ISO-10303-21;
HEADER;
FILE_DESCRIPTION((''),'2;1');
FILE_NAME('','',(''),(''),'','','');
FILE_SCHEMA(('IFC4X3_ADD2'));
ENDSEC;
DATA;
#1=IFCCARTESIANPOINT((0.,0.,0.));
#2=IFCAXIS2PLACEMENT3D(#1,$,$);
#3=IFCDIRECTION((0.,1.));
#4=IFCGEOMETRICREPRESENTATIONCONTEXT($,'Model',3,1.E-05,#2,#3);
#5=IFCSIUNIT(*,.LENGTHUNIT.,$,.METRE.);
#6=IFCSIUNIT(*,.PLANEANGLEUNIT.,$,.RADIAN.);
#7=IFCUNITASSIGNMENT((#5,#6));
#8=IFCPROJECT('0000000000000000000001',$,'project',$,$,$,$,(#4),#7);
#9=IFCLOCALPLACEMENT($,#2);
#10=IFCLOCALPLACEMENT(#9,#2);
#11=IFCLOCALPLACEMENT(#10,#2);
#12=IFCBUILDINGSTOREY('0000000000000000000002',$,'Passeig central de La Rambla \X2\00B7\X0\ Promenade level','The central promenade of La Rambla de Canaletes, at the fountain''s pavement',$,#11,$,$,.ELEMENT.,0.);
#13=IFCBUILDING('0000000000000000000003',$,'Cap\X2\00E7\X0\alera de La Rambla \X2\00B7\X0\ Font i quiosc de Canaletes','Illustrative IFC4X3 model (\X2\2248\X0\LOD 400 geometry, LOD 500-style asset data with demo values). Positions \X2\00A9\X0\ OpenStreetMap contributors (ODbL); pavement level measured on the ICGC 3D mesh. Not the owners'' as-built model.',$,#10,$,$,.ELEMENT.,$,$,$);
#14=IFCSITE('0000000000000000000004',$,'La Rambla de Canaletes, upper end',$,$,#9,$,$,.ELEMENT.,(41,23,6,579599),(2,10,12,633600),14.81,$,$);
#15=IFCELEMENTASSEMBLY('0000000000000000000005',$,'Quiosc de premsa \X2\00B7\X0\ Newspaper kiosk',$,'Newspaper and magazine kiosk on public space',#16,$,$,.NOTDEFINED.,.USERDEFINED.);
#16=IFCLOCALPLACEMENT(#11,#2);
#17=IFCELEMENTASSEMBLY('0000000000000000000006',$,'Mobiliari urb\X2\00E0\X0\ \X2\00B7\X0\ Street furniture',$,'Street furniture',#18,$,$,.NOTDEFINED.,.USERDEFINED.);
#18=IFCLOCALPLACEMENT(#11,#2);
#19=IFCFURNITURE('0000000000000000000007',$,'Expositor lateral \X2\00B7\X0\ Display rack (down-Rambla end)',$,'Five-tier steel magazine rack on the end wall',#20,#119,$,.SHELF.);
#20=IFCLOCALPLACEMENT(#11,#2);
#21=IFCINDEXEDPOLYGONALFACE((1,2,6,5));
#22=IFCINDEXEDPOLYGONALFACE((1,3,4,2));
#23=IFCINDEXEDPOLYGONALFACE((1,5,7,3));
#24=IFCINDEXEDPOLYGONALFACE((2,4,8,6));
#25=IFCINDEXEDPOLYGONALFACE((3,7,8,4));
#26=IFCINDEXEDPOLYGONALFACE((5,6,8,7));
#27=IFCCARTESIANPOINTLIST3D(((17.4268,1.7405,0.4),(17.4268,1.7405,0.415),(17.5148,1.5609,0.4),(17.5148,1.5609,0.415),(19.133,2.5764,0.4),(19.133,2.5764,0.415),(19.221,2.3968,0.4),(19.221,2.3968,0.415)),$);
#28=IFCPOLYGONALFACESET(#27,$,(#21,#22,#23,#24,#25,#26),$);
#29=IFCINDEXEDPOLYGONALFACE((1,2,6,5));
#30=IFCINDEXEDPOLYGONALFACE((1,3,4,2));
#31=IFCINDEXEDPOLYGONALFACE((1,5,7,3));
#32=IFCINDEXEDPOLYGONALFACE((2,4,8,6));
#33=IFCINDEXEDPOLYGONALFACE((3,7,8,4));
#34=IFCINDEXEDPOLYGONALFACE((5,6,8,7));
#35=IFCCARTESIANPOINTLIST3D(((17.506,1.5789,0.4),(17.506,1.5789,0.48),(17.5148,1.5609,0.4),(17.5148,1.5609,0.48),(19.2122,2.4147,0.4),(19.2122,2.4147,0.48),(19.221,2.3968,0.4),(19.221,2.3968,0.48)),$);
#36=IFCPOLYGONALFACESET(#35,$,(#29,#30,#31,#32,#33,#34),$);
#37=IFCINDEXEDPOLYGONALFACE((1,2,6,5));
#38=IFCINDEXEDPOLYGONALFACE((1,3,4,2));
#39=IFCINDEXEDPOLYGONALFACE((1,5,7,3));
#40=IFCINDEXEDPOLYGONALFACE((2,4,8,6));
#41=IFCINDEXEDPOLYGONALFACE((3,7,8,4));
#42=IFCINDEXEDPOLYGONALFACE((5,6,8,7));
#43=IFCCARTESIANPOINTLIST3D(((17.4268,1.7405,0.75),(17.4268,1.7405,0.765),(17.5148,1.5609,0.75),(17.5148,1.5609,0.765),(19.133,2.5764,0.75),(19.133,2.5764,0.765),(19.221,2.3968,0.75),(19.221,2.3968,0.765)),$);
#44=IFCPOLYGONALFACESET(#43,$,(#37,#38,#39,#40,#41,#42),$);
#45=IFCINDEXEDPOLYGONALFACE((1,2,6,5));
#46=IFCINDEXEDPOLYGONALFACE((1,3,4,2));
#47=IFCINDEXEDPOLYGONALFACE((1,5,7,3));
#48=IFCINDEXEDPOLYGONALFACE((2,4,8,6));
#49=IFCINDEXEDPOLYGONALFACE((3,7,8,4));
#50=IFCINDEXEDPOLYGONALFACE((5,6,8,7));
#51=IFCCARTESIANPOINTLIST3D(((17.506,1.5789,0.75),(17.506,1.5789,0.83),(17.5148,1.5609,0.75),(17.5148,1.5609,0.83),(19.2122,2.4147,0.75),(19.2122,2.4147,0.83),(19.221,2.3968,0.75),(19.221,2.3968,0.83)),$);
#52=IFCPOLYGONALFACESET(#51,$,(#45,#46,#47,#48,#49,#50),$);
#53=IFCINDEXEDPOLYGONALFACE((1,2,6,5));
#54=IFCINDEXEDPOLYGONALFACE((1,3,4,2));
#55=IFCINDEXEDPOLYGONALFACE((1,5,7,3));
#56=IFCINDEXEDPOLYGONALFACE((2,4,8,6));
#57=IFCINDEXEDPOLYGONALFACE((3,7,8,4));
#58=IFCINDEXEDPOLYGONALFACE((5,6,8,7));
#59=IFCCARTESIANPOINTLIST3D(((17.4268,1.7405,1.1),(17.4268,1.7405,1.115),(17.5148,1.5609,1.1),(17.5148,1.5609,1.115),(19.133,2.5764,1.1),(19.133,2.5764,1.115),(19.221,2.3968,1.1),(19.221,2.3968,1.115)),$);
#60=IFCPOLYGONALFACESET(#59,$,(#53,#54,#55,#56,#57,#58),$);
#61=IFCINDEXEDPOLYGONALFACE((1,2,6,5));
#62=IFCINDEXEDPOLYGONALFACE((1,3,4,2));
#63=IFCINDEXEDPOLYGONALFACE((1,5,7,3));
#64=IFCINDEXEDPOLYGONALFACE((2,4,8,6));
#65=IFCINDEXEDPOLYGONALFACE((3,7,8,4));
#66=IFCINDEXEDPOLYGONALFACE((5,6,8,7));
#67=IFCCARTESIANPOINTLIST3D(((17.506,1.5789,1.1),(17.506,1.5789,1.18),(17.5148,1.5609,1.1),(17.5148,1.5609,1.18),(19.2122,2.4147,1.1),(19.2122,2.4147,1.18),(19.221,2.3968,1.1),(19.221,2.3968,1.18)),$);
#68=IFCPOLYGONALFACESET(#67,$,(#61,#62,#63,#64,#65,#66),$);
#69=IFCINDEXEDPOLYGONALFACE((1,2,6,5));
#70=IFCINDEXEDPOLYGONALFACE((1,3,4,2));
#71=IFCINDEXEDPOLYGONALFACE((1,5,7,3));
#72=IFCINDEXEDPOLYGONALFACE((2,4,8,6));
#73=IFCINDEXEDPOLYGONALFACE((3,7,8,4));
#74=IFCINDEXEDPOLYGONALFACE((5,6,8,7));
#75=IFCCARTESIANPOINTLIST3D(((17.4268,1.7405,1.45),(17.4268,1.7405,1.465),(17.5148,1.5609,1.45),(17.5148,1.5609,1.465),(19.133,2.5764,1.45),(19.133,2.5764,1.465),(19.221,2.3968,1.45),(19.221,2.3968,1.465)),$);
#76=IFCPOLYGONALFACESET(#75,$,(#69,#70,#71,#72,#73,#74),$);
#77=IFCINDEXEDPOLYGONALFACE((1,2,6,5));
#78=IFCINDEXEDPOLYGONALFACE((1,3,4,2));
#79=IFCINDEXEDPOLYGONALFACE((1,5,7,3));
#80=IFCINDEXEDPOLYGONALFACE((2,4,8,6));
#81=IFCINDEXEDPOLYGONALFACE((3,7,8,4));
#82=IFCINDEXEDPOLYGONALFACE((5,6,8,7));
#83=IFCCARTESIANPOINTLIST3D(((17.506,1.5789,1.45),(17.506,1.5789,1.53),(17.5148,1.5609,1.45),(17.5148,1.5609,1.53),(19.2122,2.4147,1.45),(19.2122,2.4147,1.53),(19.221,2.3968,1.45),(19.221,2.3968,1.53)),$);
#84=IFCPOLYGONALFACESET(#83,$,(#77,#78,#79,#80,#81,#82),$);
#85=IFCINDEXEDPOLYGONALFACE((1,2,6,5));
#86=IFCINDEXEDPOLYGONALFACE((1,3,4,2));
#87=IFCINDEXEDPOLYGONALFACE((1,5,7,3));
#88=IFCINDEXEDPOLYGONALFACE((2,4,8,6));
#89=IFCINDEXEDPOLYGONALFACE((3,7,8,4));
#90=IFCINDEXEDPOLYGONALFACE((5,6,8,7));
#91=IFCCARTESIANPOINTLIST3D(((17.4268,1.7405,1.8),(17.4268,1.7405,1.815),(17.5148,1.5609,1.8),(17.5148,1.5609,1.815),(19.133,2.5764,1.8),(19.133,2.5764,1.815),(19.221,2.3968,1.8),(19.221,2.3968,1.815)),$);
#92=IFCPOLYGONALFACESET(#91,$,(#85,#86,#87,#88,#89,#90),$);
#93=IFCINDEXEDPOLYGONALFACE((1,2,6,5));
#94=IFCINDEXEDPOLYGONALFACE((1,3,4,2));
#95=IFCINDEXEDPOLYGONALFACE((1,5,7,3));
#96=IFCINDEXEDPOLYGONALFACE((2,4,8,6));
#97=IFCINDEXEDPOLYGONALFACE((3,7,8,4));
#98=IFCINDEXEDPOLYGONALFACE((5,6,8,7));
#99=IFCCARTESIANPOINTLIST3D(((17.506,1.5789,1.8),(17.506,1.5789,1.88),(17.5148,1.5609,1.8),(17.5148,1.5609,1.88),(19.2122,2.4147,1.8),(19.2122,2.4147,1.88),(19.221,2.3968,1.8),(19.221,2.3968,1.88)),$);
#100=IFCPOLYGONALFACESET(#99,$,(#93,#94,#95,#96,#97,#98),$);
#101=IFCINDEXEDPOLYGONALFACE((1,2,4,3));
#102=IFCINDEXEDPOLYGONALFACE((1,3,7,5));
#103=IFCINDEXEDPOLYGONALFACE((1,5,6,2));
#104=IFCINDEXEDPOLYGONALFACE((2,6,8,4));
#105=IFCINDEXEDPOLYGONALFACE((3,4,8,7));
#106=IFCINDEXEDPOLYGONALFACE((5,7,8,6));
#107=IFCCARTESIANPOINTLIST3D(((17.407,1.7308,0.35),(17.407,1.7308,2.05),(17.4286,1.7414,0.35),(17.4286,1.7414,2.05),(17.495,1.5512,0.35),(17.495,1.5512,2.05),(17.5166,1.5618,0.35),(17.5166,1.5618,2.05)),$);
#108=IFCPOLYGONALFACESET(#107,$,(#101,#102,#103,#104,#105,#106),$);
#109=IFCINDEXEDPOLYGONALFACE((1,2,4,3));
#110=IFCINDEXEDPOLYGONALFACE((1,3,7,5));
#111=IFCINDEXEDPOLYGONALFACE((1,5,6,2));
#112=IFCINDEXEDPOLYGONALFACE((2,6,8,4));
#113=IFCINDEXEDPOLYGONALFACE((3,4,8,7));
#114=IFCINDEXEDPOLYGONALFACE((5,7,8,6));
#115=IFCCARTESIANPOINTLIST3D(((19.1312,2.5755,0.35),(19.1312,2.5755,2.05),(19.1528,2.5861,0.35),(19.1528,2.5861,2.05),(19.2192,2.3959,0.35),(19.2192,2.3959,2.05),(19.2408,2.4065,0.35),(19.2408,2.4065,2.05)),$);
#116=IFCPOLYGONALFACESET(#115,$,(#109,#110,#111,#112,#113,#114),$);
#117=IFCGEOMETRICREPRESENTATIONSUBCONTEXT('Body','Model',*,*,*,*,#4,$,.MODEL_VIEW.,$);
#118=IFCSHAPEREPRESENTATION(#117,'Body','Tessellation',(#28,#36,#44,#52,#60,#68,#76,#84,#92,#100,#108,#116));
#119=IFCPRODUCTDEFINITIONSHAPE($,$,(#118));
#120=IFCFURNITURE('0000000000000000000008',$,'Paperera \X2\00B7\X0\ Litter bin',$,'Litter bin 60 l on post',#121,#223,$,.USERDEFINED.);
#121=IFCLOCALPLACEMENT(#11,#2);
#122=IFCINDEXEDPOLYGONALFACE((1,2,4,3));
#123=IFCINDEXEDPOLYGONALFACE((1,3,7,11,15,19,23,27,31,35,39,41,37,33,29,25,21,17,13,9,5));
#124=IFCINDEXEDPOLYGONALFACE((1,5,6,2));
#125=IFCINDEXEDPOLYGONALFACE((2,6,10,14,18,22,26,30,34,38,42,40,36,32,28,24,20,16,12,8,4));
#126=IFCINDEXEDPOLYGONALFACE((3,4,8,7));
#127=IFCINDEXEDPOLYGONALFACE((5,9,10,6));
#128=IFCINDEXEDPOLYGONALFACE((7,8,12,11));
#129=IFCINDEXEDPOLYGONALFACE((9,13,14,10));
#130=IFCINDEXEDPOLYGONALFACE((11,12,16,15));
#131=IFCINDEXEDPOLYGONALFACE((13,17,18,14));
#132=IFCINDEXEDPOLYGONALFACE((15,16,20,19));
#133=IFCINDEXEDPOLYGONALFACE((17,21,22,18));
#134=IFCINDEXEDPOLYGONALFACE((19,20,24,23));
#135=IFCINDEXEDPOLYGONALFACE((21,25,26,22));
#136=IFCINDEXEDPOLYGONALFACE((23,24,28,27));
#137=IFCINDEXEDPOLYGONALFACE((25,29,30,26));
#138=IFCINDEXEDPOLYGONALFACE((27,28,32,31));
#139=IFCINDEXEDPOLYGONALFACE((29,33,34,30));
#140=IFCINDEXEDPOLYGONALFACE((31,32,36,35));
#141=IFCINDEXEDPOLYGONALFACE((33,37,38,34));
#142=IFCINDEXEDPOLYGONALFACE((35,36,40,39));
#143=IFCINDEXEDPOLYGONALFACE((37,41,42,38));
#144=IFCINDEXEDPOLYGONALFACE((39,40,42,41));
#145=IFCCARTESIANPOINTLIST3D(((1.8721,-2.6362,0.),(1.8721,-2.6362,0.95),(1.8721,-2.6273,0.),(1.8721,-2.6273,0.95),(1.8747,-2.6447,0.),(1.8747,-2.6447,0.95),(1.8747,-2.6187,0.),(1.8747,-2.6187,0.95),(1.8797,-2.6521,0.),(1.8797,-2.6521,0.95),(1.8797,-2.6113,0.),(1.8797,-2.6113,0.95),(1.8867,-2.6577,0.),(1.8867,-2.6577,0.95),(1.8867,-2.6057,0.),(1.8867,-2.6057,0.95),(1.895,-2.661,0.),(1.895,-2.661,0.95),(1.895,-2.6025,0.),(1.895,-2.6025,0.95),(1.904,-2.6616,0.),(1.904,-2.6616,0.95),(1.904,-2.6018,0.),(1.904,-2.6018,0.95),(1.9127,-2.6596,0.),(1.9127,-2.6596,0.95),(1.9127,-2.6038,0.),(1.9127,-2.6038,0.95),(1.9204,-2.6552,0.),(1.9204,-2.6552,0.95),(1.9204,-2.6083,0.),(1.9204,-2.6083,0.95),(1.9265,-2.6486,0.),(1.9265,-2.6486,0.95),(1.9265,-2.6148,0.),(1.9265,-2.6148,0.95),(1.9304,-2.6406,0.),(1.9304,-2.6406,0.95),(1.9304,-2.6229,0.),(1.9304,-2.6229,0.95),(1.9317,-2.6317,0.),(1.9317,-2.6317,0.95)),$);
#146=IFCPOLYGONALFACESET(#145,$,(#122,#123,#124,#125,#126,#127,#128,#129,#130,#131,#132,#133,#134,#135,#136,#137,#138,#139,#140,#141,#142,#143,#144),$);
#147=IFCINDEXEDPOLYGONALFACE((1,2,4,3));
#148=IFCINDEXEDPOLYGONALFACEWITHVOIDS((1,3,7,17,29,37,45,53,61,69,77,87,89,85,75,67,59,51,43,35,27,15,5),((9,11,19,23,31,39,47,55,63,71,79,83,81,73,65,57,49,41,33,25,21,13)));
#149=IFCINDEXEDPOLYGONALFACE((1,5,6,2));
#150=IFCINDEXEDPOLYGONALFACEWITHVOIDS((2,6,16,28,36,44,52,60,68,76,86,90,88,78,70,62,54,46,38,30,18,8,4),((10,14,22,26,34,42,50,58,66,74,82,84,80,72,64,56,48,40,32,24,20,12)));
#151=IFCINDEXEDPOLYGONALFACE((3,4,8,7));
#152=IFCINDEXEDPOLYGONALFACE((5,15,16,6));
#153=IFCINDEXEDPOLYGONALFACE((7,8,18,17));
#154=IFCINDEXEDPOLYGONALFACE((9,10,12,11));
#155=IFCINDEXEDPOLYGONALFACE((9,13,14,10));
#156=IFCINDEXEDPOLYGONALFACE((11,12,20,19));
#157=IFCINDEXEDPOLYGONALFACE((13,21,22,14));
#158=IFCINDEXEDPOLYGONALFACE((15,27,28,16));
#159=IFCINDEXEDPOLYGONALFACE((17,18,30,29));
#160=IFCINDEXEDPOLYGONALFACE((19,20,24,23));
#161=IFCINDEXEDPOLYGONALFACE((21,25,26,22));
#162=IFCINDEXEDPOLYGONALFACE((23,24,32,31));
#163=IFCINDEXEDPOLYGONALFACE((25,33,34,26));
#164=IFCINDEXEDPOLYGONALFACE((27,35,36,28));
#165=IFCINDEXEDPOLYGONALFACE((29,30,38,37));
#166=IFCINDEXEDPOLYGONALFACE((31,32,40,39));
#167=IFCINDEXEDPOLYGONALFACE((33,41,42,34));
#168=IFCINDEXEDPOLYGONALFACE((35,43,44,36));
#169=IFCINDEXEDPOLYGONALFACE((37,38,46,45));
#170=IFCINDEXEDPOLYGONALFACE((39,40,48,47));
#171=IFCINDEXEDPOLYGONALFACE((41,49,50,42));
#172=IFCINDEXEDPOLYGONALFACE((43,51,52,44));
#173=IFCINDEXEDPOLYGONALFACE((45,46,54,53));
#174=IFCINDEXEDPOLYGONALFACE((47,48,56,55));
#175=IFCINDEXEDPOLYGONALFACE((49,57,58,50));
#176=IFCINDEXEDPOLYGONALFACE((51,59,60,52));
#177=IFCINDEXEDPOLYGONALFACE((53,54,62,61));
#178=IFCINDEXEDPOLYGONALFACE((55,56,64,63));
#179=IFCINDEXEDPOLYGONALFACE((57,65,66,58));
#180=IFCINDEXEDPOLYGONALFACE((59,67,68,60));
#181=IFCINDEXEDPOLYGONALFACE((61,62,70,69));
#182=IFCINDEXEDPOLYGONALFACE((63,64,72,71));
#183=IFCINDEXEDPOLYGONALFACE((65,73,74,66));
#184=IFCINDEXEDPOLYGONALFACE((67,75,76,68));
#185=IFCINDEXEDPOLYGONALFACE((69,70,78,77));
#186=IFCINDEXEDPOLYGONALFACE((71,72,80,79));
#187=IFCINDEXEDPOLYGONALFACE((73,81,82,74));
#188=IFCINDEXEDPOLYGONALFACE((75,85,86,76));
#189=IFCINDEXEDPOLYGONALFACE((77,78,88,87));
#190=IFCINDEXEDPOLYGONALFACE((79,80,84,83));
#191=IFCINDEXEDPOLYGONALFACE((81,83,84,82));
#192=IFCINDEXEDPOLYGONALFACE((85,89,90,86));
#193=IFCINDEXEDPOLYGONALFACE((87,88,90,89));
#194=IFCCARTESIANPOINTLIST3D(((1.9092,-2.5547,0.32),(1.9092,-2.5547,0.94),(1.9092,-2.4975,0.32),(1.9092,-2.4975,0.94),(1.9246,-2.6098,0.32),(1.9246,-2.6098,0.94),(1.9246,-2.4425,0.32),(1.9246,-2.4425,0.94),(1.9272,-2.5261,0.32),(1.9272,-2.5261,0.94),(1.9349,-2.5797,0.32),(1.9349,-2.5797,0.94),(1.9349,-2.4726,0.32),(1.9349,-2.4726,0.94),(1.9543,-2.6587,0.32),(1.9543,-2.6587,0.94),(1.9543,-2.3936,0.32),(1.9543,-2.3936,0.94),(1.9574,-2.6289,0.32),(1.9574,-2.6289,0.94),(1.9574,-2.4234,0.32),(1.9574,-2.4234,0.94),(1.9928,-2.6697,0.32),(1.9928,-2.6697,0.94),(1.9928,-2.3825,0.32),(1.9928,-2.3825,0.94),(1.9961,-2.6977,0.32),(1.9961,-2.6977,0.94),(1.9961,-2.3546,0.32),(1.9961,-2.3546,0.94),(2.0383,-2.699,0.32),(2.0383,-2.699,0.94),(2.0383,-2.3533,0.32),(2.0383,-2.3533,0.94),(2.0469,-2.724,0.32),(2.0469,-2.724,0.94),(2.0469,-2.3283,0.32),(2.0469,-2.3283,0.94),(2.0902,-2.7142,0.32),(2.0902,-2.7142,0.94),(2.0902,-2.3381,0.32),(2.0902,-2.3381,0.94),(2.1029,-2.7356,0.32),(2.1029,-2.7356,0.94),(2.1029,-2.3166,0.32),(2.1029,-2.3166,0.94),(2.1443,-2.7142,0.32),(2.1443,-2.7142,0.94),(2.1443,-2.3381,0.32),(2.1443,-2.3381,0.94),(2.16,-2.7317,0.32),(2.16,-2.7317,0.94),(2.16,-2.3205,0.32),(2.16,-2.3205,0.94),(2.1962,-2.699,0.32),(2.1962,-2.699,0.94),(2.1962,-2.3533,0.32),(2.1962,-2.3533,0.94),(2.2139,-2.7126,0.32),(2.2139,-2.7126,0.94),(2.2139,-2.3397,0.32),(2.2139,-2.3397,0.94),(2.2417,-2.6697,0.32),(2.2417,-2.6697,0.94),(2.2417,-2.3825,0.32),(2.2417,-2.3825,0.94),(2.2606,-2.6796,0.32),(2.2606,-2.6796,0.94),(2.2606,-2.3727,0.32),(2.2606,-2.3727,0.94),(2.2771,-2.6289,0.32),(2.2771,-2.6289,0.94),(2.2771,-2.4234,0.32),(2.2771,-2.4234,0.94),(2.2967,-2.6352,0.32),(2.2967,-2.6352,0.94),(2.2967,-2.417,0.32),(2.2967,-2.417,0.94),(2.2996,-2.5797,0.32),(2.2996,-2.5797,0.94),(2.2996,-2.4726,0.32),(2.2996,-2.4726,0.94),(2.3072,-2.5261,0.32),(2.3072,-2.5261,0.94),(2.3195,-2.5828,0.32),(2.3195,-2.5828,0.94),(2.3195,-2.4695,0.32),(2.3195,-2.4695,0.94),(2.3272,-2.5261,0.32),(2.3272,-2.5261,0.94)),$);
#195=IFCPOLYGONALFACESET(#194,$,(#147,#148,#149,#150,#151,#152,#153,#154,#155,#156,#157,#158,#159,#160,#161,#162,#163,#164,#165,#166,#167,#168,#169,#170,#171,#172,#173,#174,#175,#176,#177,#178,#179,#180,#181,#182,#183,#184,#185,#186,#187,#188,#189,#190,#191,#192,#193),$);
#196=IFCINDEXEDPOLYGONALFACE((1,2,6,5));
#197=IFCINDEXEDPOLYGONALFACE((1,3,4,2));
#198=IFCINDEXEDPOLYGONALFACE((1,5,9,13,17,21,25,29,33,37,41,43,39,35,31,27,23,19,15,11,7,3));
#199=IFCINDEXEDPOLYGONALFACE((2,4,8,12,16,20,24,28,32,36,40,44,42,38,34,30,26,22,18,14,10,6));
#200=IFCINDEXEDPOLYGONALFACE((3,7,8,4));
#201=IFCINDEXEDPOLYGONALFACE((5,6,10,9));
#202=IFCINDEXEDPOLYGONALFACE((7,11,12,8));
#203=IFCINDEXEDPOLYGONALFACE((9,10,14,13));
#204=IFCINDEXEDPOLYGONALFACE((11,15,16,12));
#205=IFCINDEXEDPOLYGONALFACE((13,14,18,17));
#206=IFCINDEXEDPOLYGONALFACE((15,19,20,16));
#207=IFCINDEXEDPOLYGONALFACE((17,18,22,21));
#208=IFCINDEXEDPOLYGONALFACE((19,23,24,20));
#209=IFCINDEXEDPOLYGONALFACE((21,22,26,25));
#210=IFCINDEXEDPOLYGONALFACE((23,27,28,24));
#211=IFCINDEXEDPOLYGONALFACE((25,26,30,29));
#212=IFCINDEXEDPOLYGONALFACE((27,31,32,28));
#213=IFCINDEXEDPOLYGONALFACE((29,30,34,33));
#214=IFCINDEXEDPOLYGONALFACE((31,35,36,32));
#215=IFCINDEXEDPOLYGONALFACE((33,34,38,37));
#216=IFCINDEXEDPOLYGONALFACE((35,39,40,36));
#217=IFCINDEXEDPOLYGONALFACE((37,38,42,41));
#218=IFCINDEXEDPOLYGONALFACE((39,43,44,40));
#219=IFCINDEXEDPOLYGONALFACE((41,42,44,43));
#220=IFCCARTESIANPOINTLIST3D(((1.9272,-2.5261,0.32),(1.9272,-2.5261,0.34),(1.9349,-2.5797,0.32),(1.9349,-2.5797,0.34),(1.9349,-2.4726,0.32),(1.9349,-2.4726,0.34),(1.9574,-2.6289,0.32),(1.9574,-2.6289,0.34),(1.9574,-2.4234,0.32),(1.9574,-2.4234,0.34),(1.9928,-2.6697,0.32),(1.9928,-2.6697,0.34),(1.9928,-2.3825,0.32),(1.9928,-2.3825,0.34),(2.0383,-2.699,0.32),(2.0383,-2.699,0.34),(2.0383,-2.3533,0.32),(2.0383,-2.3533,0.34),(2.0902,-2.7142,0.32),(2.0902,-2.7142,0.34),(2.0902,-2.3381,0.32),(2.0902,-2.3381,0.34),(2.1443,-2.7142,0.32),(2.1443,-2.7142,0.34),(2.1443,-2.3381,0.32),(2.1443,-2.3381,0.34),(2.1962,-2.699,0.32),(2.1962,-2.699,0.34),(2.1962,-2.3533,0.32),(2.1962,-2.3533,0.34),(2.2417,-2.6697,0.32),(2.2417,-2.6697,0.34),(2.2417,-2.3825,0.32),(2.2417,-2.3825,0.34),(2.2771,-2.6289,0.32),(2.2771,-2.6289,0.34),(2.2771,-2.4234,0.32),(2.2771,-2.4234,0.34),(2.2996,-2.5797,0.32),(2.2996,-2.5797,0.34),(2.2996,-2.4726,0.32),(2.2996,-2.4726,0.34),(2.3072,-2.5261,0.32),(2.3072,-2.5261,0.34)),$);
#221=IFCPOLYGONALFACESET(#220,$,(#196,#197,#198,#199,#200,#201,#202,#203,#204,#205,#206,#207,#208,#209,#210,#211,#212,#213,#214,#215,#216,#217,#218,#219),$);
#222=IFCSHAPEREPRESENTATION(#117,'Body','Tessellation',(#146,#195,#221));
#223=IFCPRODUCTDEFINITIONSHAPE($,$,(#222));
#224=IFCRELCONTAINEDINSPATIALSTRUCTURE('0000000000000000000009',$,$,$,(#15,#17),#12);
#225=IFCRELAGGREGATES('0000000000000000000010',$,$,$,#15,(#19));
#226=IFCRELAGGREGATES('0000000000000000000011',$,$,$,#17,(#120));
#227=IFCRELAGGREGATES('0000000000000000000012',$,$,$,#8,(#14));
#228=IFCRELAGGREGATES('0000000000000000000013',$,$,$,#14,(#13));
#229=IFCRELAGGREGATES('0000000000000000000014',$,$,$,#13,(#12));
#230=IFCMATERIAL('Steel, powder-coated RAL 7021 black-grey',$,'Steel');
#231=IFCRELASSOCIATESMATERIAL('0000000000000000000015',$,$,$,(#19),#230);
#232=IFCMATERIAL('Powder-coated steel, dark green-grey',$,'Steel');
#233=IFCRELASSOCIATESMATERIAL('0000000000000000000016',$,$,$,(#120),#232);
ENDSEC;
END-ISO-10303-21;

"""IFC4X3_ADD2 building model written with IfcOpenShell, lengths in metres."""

from ifc_helpers import new_model, si_unit, direction, frame, frame_2d, origin, origin_2d_with_axis, place, context, subcontext, project, spatial, rectangle, circle, hollow_circle, extrude, material, element, aggregate, save


model = new_model("IFC4X3_ADD2")

# Units and contexts
model_context = context("Model", 3, precision=1e-05, world=origin(), true_north=direction((0.0, 1.0)))
body_context = subcontext(model_context, "Body", "Model", "MODEL_VIEW")
ifc_project = project(units=[si_unit("LENGTHUNIT", "METRE"), si_unit("PLANEANGLEUNIT", "RADIAN")], contexts=[model_context])

# Site, building, storey
site_placement = place(None, origin())
site = spatial("IfcSite", under=ifc_project, at=site_placement, Name="La Rambla de Canaletes, upper end", CompositionType="ELEMENT", RefLatitude=(41, 23, 6, 579599), RefLongitude=(2, 10, 12, 633600), RefElevation=14.81)
building_placement = place(site_placement, origin())
building = spatial("IfcBuilding", under=site, at=building_placement, Name="Capçalera de La Rambla · Font i quiosc de Canaletes", Description="Illustrative IFC4X3 model (≈LOD 400 geometry, LOD 500-style asset data with demo values). Positions © OpenStreetMap contributors (ODbL); pavement level measured on the ICGC 3D mesh. Not the owners' as-built model.", CompositionType="ELEMENT")
storey_placement = place(building_placement, origin())
storey = spatial("IfcBuildingStorey", under=building, at=storey_placement, Name="Passeig central de La Rambla · Promenade level", Description="The central promenade of La Rambla de Canaletes, at the fountain's pavement", CompositionType="ELEMENT", Elevation=0.0)

# Element assembly
assembly_1_placement = place(building_placement, origin())
assembly_1 = element("IfcElementAssembly", 1, at=assembly_1_placement, inside=storey, Name="Quiosc de premsa · Newspaper kiosk", ObjectType="Newspaper and magazine kiosk on public space", AssemblyPlace="NOTDEFINED", PredefinedType="USERDEFINED")
ifc_material_1 = material(Name="Steel, powder-coated RAL 7021 black-grey", Category="Steel")

# Element assembly
assembly_2_placement = place(building_placement, origin())
assembly_2 = element("IfcElementAssembly", 2, at=assembly_2_placement, inside=storey, Name="Mobiliari urbà · Street furniture", ObjectType="Street furniture", AssemblyPlace="NOTDEFINED", PredefinedType="USERDEFINED")

# Furniture
furniture_1_placement = place(building_placement, origin())
furniture_1 = element("IfcFurniture", 3, at=furniture_1_placement, material=ifc_material_1, Name="Expositor lateral · Display rack (down-Rambla end)", ObjectType="Five-tier steel magazine rack on the end wall", PredefinedType="SHELF", context=body_context, shape_type="SweptSolid", body=[
    extrude(rectangle(XDim=0.2, YDim=1.9, at=frame_2d((0.0, 0.0), x_axis=(0.439939, -0.898028))), frame((18.3239, 2.0686, 0.4)), (0.0, 0.0, 1.0), 0.015),
    extrude(rectangle(XDim=0.02, YDim=1.9, at=frame_2d((0.0, 0.0), x_axis=(0.439939, -0.898028))), frame((18.3635, 1.9878, 0.4)), (0.0, 0.0, 1.0), 0.08),
    extrude(rectangle(XDim=0.2, YDim=1.9, at=frame_2d((0.0, 0.0), x_axis=(0.439939, -0.898028))), frame((18.3239, 2.0686, 0.75)), (0.0, 0.0, 1.0), 0.015),
    extrude(rectangle(XDim=0.02, YDim=1.9, at=frame_2d((0.0, 0.0), x_axis=(0.439939, -0.898028))), frame((18.3635, 1.9878, 0.75)), (0.0, 0.0, 1.0), 0.08),
    extrude(rectangle(XDim=0.2, YDim=1.9, at=frame_2d((0.0, 0.0), x_axis=(0.439939, -0.898028))), frame((18.3239, 2.0686, 1.1)), (0.0, 0.0, 1.0), 0.015),
    extrude(rectangle(XDim=0.02, YDim=1.9, at=frame_2d((0.0, 0.0), x_axis=(0.439939, -0.898028))), frame((18.3635, 1.9878, 1.1)), (0.0, 0.0, 1.0), 0.08),
    extrude(rectangle(XDim=0.2, YDim=1.9, at=frame_2d((0.0, 0.0), x_axis=(0.439939, -0.898028))), frame((18.3239, 2.0686, 1.45)), (0.0, 0.0, 1.0), 0.015),
    extrude(rectangle(XDim=0.02, YDim=1.9, at=frame_2d((0.0, 0.0), x_axis=(0.439939, -0.898028))), frame((18.3635, 1.9878, 1.45)), (0.0, 0.0, 1.0), 0.08),
    extrude(rectangle(XDim=0.2, YDim=1.9, at=frame_2d((0.0, 0.0), x_axis=(0.439939, -0.898028))), frame((18.3239, 2.0686, 1.8)), (0.0, 0.0, 1.0), 0.015),
    extrude(rectangle(XDim=0.02, YDim=1.9, at=frame_2d((0.0, 0.0), x_axis=(0.439939, -0.898028))), frame((18.3635, 1.9878, 1.8)), (0.0, 0.0, 1.0), 0.08),
    extrude(rectangle(XDim=0.2, YDim=0.024, at=frame_2d((0.0, 0.0), x_axis=(0.439939, -0.898028))), frame((17.4618, 1.6463, 0.35)), (0.0, 0.0, 1.0), 1.7),
    extrude(rectangle(XDim=0.2, YDim=0.024, at=frame_2d((0.0, 0.0), x_axis=(0.439939, -0.898028))), frame((19.186, 2.491, 0.35)), (0.0, 0.0, 1.0), 1.7),
])
ifc_material_2 = material(Name="Powder-coated steel, dark green-grey", Category="Steel")
furniture_2_placement = place(building_placement, origin())
furniture_2 = element("IfcFurniture", 4, at=furniture_2_placement, material=ifc_material_2, Name="Paperera · Litter bin", ObjectType="Litter bin 60 l on post", PredefinedType="USERDEFINED", context=body_context, shape_type="SweptSolid", body=[
    extrude(circle(Radius=0.03, at=origin_2d_with_axis()), frame((1.9017, -2.6317, 0.0)), (0.0, 0.0, 1.0), 0.95),
    extrude(hollow_circle(Radius=0.21, WallThickness=0.02, at=origin_2d_with_axis()), frame((2.1172, -2.5261, 0.32)), (0.0, 0.0, 1.0), 0.62),
    extrude(circle(Radius=0.19, at=origin_2d_with_axis()), frame((2.1172, -2.5261, 0.32)), (0.0, 0.0, 1.0), 0.02),
])

aggregate(assembly_1, [furniture_1])

aggregate(assembly_2, [furniture_2])

save(model, "model.ifc")
